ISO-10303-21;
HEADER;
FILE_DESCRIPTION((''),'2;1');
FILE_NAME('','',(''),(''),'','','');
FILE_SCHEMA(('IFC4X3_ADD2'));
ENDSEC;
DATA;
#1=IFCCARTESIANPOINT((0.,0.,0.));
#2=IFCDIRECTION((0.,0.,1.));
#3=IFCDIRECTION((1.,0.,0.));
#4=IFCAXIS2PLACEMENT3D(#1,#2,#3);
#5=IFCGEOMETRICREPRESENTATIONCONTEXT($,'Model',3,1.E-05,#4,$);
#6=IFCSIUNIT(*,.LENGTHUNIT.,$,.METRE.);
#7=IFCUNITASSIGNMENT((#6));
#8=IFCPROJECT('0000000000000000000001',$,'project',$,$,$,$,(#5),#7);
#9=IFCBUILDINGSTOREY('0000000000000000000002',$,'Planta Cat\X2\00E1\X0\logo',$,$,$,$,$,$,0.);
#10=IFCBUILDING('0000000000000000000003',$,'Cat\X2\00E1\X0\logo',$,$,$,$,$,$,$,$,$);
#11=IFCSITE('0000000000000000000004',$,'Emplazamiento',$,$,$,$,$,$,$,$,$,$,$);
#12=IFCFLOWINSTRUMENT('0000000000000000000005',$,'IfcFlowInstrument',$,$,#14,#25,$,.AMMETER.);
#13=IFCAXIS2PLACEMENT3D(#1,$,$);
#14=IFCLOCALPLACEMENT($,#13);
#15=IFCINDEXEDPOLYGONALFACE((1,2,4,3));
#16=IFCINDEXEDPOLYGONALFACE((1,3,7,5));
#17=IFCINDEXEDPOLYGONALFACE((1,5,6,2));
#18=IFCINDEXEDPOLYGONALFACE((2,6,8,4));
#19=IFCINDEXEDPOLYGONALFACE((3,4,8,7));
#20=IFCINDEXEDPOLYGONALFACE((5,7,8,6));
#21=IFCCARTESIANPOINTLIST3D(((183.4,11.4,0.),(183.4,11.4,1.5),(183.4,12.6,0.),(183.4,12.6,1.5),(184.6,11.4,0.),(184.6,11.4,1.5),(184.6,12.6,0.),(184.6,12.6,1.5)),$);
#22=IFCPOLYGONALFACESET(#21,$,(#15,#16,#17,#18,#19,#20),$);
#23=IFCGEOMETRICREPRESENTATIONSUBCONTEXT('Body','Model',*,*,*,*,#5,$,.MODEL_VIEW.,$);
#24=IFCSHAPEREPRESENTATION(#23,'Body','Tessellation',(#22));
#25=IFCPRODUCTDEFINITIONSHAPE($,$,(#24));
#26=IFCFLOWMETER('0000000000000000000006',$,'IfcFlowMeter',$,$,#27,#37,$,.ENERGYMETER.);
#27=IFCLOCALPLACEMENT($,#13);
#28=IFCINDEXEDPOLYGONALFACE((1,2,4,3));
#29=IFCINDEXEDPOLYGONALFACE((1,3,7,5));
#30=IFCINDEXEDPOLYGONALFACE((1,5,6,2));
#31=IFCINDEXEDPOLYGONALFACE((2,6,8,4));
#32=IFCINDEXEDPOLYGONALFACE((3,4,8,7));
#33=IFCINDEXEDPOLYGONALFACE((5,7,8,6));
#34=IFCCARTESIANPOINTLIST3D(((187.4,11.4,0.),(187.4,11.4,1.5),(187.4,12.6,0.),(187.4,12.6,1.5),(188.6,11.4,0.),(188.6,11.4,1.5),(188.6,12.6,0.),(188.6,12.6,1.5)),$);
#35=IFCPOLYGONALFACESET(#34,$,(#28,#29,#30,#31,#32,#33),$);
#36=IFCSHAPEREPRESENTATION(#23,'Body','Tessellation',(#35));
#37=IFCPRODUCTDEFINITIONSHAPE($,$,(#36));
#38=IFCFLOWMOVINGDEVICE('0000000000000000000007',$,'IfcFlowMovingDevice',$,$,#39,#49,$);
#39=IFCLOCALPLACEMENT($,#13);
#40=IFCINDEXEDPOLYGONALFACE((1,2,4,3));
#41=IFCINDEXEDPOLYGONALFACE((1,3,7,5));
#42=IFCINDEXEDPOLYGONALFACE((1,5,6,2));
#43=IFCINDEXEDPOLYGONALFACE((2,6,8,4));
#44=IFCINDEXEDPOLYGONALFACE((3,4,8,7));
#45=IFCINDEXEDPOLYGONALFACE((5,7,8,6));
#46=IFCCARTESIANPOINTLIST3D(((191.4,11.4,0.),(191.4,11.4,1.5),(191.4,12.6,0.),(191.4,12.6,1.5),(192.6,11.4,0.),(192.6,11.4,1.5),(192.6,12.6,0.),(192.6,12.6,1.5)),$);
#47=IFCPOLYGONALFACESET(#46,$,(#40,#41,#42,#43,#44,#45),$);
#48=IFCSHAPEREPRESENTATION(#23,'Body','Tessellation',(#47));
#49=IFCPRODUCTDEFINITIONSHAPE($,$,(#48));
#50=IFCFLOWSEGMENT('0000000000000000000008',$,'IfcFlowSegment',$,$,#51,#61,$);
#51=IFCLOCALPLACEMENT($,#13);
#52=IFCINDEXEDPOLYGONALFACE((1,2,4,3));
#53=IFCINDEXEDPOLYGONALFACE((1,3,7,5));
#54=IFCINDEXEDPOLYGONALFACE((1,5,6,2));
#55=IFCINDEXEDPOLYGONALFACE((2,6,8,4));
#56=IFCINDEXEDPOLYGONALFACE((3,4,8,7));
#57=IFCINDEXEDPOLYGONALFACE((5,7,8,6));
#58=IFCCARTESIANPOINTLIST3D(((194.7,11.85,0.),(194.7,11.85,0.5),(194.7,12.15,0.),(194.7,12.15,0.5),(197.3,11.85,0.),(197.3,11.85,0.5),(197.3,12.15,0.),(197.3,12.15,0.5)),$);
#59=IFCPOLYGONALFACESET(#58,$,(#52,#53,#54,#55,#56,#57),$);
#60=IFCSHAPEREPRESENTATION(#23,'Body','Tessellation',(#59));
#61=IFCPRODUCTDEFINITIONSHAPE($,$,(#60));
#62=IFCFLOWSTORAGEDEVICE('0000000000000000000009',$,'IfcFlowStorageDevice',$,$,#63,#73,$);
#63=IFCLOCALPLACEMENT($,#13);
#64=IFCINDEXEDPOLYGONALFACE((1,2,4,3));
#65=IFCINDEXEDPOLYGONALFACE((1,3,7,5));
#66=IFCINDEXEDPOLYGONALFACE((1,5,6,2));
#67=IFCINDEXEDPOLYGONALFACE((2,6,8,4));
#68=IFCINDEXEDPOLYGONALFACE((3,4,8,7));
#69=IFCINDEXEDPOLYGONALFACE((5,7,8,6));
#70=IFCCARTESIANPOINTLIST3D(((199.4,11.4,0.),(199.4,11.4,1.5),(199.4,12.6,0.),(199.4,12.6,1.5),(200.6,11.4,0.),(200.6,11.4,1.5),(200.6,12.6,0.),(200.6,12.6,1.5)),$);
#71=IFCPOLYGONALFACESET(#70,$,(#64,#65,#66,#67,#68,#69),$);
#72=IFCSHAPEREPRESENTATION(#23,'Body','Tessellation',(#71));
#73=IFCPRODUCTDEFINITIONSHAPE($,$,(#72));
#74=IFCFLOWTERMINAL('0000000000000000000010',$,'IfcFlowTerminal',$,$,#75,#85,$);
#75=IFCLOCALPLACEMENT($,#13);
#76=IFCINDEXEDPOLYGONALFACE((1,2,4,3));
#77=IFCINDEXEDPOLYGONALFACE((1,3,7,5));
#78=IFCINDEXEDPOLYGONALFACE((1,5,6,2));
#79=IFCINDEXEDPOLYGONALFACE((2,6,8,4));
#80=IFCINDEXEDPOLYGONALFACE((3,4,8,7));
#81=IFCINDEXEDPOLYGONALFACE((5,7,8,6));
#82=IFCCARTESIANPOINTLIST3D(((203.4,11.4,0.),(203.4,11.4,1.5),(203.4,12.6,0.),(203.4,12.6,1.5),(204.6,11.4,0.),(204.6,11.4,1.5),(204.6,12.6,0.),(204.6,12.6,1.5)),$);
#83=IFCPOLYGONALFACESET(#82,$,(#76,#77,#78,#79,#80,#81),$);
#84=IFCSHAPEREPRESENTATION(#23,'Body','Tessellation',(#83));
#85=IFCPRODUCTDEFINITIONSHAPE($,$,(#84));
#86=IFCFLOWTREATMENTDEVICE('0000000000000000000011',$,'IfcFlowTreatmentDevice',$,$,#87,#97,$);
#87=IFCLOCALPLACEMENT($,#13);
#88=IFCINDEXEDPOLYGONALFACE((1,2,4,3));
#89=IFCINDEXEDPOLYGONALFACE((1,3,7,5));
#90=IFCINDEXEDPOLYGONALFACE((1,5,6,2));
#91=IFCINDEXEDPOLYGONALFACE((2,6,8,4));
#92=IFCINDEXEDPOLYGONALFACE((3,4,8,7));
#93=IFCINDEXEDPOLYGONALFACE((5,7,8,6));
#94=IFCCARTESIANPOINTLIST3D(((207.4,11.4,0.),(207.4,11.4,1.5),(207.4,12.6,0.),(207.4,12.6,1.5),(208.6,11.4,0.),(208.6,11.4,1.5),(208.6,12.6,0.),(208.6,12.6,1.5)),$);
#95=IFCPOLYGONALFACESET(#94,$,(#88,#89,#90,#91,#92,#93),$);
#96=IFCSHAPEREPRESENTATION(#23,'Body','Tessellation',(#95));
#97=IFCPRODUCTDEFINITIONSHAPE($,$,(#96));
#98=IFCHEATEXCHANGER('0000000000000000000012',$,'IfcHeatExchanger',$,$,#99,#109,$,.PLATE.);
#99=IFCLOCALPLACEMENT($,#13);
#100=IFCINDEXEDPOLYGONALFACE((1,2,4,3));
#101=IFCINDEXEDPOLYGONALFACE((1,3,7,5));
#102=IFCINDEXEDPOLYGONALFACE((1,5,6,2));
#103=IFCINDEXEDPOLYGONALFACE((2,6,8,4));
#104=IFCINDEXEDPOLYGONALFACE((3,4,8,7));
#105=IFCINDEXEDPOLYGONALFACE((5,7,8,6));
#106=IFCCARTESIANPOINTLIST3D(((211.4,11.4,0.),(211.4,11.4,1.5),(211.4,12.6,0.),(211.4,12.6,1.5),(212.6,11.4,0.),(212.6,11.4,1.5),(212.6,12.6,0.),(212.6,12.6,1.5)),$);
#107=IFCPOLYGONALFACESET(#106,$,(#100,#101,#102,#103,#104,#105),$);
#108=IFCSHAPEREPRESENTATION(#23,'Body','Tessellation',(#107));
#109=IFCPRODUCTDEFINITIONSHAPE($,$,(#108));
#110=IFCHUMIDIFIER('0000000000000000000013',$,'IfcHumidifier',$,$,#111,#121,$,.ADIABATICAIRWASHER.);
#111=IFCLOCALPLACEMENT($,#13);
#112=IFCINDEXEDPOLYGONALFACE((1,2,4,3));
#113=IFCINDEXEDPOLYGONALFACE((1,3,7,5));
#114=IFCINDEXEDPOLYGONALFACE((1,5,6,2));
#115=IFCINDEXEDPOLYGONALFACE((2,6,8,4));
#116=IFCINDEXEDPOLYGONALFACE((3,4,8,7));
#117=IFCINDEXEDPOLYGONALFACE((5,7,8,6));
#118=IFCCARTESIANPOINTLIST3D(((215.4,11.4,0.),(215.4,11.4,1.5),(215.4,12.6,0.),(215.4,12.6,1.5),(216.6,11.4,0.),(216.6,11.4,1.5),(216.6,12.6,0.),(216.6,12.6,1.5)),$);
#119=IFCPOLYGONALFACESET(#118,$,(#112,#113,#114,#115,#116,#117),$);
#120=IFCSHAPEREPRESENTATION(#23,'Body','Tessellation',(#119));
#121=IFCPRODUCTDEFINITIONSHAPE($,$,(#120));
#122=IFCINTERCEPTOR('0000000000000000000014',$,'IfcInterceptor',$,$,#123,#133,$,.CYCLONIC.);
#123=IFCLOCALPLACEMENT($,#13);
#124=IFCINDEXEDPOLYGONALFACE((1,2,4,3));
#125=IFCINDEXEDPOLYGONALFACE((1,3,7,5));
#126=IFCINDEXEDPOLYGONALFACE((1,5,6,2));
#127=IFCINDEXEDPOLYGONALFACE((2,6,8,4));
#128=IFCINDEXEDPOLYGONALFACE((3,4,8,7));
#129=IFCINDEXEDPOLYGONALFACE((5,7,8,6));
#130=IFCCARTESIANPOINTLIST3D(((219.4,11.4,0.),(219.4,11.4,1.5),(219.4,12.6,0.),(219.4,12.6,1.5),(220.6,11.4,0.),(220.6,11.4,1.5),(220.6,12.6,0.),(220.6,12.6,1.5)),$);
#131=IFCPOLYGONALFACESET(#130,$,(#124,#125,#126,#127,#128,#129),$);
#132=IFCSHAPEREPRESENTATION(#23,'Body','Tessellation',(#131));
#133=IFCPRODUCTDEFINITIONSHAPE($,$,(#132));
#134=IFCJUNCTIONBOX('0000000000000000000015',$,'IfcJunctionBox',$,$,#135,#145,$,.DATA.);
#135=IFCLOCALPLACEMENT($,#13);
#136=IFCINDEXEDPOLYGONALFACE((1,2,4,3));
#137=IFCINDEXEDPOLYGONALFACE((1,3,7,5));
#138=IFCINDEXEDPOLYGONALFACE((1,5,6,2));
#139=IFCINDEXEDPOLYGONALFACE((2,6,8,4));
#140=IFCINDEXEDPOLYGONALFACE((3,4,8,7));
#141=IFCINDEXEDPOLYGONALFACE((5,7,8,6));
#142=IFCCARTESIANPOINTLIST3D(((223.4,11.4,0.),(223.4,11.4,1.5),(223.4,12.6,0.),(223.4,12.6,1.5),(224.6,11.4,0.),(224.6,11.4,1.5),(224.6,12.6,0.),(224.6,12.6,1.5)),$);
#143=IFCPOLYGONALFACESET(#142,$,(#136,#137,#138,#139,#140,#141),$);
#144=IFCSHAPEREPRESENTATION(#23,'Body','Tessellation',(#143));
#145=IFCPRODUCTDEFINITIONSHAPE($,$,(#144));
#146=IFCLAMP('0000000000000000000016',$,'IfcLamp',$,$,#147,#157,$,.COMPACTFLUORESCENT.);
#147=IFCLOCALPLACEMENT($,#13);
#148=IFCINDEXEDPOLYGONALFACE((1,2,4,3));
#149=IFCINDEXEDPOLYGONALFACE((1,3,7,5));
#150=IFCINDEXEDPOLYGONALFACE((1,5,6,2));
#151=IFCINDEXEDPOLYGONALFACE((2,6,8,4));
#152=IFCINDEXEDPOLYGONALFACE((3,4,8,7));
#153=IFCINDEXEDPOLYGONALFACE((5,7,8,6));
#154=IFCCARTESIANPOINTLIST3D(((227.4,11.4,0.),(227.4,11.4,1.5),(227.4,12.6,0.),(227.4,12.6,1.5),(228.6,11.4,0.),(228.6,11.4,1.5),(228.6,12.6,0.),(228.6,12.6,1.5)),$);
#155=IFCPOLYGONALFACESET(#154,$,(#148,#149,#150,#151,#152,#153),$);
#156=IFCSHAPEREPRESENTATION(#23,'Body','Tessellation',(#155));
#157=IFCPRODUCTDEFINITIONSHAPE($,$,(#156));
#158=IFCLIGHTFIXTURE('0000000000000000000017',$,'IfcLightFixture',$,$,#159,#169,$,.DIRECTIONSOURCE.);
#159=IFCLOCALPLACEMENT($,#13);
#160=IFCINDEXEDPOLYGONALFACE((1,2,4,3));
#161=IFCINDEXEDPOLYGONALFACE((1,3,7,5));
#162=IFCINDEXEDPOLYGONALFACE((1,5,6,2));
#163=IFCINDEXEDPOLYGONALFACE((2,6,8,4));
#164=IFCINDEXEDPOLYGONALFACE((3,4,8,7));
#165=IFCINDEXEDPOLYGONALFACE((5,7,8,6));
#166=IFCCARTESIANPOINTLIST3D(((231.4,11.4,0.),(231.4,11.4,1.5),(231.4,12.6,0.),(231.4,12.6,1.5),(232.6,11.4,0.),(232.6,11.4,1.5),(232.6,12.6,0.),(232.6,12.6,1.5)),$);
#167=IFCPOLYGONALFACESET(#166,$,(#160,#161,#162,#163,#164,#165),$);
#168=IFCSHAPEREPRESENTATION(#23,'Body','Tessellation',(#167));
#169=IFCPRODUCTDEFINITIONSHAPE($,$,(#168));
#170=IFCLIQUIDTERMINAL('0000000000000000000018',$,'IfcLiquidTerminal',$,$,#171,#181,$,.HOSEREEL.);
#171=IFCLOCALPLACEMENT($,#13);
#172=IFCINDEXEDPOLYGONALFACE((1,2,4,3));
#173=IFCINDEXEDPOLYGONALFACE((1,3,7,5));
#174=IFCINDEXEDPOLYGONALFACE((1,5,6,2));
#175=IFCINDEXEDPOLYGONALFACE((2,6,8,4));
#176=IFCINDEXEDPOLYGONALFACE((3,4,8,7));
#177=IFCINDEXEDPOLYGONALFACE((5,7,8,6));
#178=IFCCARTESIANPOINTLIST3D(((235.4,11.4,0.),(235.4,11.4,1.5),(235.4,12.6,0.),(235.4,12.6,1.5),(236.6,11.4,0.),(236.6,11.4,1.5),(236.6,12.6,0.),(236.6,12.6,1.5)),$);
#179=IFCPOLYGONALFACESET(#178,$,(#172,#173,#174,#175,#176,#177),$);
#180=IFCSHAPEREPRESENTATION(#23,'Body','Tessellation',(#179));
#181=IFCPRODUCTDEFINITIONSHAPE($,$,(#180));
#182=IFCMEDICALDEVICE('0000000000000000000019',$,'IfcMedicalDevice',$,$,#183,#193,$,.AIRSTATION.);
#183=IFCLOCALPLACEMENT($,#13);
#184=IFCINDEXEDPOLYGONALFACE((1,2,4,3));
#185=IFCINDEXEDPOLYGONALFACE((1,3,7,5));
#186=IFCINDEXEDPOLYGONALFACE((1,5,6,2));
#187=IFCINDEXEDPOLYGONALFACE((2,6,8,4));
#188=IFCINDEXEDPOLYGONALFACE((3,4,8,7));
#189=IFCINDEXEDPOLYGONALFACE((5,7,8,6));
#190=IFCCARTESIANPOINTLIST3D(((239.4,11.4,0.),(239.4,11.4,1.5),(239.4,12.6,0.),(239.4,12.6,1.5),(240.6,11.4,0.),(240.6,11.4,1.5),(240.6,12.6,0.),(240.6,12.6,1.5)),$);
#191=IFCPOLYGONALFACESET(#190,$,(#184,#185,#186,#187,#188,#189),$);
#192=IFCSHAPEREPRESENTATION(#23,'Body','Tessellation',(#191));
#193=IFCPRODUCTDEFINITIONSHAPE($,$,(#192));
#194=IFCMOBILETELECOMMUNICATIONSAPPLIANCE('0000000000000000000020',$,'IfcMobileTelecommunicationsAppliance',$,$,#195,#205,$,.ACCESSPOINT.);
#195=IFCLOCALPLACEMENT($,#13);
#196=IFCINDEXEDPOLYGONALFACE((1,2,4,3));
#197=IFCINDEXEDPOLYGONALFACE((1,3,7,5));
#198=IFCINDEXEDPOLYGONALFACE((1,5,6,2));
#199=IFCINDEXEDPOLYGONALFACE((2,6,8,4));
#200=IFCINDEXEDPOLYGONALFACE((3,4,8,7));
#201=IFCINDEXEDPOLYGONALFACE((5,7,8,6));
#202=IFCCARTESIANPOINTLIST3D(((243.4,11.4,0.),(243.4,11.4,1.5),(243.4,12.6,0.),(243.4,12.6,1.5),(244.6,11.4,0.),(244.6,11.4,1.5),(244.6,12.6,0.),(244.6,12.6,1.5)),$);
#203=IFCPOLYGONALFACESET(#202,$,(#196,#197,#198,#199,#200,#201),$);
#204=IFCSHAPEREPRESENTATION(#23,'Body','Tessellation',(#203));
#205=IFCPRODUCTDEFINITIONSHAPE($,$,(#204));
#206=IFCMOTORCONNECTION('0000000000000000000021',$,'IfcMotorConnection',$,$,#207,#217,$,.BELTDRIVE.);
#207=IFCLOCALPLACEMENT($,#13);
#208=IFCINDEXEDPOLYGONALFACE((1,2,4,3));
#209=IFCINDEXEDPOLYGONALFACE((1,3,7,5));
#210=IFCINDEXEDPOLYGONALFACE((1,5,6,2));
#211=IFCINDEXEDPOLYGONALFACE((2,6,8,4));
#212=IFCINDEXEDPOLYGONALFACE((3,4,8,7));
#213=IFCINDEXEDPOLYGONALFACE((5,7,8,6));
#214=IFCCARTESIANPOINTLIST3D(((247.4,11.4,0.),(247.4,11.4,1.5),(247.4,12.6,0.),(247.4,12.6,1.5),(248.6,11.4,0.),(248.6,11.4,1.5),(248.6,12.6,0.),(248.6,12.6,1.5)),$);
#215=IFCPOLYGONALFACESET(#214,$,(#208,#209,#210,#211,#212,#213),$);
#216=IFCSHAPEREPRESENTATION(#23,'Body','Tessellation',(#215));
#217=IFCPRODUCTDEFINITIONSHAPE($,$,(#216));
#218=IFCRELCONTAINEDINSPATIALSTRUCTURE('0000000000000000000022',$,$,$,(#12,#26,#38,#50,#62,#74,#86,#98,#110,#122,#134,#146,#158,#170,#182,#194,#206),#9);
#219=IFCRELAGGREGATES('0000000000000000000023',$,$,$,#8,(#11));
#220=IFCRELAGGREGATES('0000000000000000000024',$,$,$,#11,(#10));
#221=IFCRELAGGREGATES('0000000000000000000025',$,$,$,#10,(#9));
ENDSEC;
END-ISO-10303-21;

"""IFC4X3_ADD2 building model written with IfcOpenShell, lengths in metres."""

from ifc_helpers import new_model, si_unit, frame, origin, origin_with_axes, origin_2d, place, context, subcontext, project, spatial, rectangle, extrude, element, save


model = new_model("IFC4X3_ADD2")

# Units and contexts
model_context = context("Model", 3, precision=1e-05, world=origin_with_axes())
body_context = subcontext(model_context, "Body", "Model", "MODEL_VIEW")
ifc_project = project(units=[si_unit("LENGTHUNIT", "METRE")], contexts=[model_context])

# Site, building, storey
site = spatial("IfcSite", under=ifc_project, Name="Emplazamiento")
building = spatial("IfcBuilding", under=site, Name="Catálogo")
storey = spatial("IfcBuildingStorey", under=building, Name="Planta Catálogo", Elevation=0.0)

# Flow instrument
flow_instrument_placement = place(None, frame((184.0, 12.0, 0.0), z_axis=(0.0, 0.0, 1.0), x_axis=(1.0, 0.0, 0.0)))
element("IfcFlowInstrument", 1, at=flow_instrument_placement, inside=storey, Name="IfcFlowInstrument", PredefinedType="AMMETER", context=body_context, shape_type="SweptSolid", body=[
    extrude(rectangle(XDim=1.2, YDim=1.2, at=origin_2d()), origin(), (0.0, 0.0, 1.0), 1.5),
])

# Flow meter
flow_meter_placement = place(None, frame((188.0, 12.0, 0.0), z_axis=(0.0, 0.0, 1.0), x_axis=(1.0, 0.0, 0.0)))
element("IfcFlowMeter", 2, at=flow_meter_placement, inside=storey, Name="IfcFlowMeter", PredefinedType="ENERGYMETER", context=body_context, shape_type="SweptSolid", body=[
    extrude(rectangle(XDim=1.2, YDim=1.2, at=origin_2d()), origin(), (0.0, 0.0, 1.0), 1.5),
])

# Flow moving device
flow_moving_device_placement = place(None, frame((192.0, 12.0, 0.0), z_axis=(0.0, 0.0, 1.0), x_axis=(1.0, 0.0, 0.0)))
element("IfcFlowMovingDevice", 3, at=flow_moving_device_placement, inside=storey, Name="IfcFlowMovingDevice", context=body_context, shape_type="SweptSolid", body=[
    extrude(rectangle(XDim=1.2, YDim=1.2, at=origin_2d()), origin(), (0.0, 0.0, 1.0), 1.5),
])

# Flow segment
flow_segment_placement = place(None, frame((196.0, 12.0, 0.0), z_axis=(0.0, 0.0, 1.0), x_axis=(1.0, 0.0, 0.0)))
element("IfcFlowSegment", 4, at=flow_segment_placement, inside=storey, Name="IfcFlowSegment", context=body_context, shape_type="SweptSolid", body=[
    extrude(rectangle(XDim=2.6, YDim=0.3, at=origin_2d()), origin(), (0.0, 0.0, 1.0), 0.5),
])

# Flow storage device
flow_storage_device_placement = place(None, frame((200.0, 12.0, 0.0), z_axis=(0.0, 0.0, 1.0), x_axis=(1.0, 0.0, 0.0)))
element("IfcFlowStorageDevice", 5, at=flow_storage_device_placement, inside=storey, Name="IfcFlowStorageDevice", context=body_context, shape_type="SweptSolid", body=[
    extrude(rectangle(XDim=1.2, YDim=1.2, at=origin_2d()), origin(), (0.0, 0.0, 1.0), 1.5),
])

# Flow terminal
flow_terminal_placement = place(None, frame((204.0, 12.0, 0.0), z_axis=(0.0, 0.0, 1.0), x_axis=(1.0, 0.0, 0.0)))
element("IfcFlowTerminal", 6, at=flow_terminal_placement, inside=storey, Name="IfcFlowTerminal", context=body_context, shape_type="SweptSolid", body=[
    extrude(rectangle(XDim=1.2, YDim=1.2, at=origin_2d()), origin(), (0.0, 0.0, 1.0), 1.5),
])

# Flow treatment device
flow_treatment_device_placement = place(None, frame((208.0, 12.0, 0.0), z_axis=(0.0, 0.0, 1.0), x_axis=(1.0, 0.0, 0.0)))
element("IfcFlowTreatmentDevice", 7, at=flow_treatment_device_placement, inside=storey, Name="IfcFlowTreatmentDevice", context=body_context, shape_type="SweptSolid", body=[
    extrude(rectangle(XDim=1.2, YDim=1.2, at=origin_2d()), origin(), (0.0, 0.0, 1.0), 1.5),
])

# Heat exchanger
heat_exchanger_placement = place(None, frame((212.0, 12.0, 0.0), z_axis=(0.0, 0.0, 1.0), x_axis=(1.0, 0.0, 0.0)))
element("IfcHeatExchanger", 8, at=heat_exchanger_placement, inside=storey, Name="IfcHeatExchanger", PredefinedType="PLATE", context=body_context, shape_type="SweptSolid", body=[
    extrude(rectangle(XDim=1.2, YDim=1.2, at=origin_2d()), origin(), (0.0, 0.0, 1.0), 1.5),
])

# Humidifier
humidifier_placement = place(None, frame((216.0, 12.0, 0.0), z_axis=(0.0, 0.0, 1.0), x_axis=(1.0, 0.0, 0.0)))
element("IfcHumidifier", 9, at=humidifier_placement, inside=storey, Name="IfcHumidifier", PredefinedType="ADIABATICAIRWASHER", context=body_context, shape_type="SweptSolid", body=[
    extrude(rectangle(XDim=1.2, YDim=1.2, at=origin_2d()), origin(), (0.0, 0.0, 1.0), 1.5),
])

# Interceptor
interceptor_placement = place(None, frame((220.0, 12.0, 0.0), z_axis=(0.0, 0.0, 1.0), x_axis=(1.0, 0.0, 0.0)))
element("IfcInterceptor", 10, at=interceptor_placement, inside=storey, Name="IfcInterceptor", PredefinedType="CYCLONIC", context=body_context, shape_type="SweptSolid", body=[
    extrude(rectangle(XDim=1.2, YDim=1.2, at=origin_2d()), origin(), (0.0, 0.0, 1.0), 1.5),
])

# Junction box
junction_box_placement = place(None, frame((224.0, 12.0, 0.0), z_axis=(0.0, 0.0, 1.0), x_axis=(1.0, 0.0, 0.0)))
element("IfcJunctionBox", 11, at=junction_box_placement, inside=storey, Name="IfcJunctionBox", PredefinedType="DATA", context=body_context, shape_type="SweptSolid", body=[
    extrude(rectangle(XDim=1.2, YDim=1.2, at=origin_2d()), origin(), (0.0, 0.0, 1.0), 1.5),
])

# Lamp
lamp_placement = place(None, frame((228.0, 12.0, 0.0), z_axis=(0.0, 0.0, 1.0), x_axis=(1.0, 0.0, 0.0)))
element("IfcLamp", 12, at=lamp_placement, inside=storey, Name="IfcLamp", PredefinedType="COMPACTFLUORESCENT", context=body_context, shape_type="SweptSolid", body=[
    extrude(rectangle(XDim=1.2, YDim=1.2, at=origin_2d()), origin(), (0.0, 0.0, 1.0), 1.5),
])

# Light fixture
light_fixture_placement = place(None, frame((232.0, 12.0, 0.0), z_axis=(0.0, 0.0, 1.0), x_axis=(1.0, 0.0, 0.0)))
element("IfcLightFixture", 13, at=light_fixture_placement, inside=storey, Name="IfcLightFixture", PredefinedType="DIRECTIONSOURCE", context=body_context, shape_type="SweptSolid", body=[
    extrude(rectangle(XDim=1.2, YDim=1.2, at=origin_2d()), origin(), (0.0, 0.0, 1.0), 1.5),
])

# Liquid terminal
liquid_terminal_placement = place(None, frame((236.0, 12.0, 0.0), z_axis=(0.0, 0.0, 1.0), x_axis=(1.0, 0.0, 0.0)))
element("IfcLiquidTerminal", 14, at=liquid_terminal_placement, inside=storey, Name="IfcLiquidTerminal", PredefinedType="HOSEREEL", context=body_context, shape_type="SweptSolid", body=[
    extrude(rectangle(XDim=1.2, YDim=1.2, at=origin_2d()), origin(), (0.0, 0.0, 1.0), 1.5),
])

# Medical device
medical_device_placement = place(None, frame((240.0, 12.0, 0.0), z_axis=(0.0, 0.0, 1.0), x_axis=(1.0, 0.0, 0.0)))
element("IfcMedicalDevice", 15, at=medical_device_placement, inside=storey, Name="IfcMedicalDevice", PredefinedType="AIRSTATION", context=body_context, shape_type="SweptSolid", body=[
    extrude(rectangle(XDim=1.2, YDim=1.2, at=origin_2d()), origin(), (0.0, 0.0, 1.0), 1.5),
])

# Mobile telecommunications appliance
mobile_telecommunications_appliance_placement = place(None, frame((244.0, 12.0, 0.0), z_axis=(0.0, 0.0, 1.0), x_axis=(1.0, 0.0, 0.0)))
element("IfcMobileTelecommunicationsAppliance", 16, at=mobile_telecommunications_appliance_placement, inside=storey, Name="IfcMobileTelecommunicationsAppliance", PredefinedType="ACCESSPOINT", context=body_context, shape_type="SweptSolid", body=[
    extrude(rectangle(XDim=1.2, YDim=1.2, at=origin_2d()), origin(), (0.0, 0.0, 1.0), 1.5),
])

# Motor connection
motor_connection_placement = place(None, frame((248.0, 12.0, 0.0), z_axis=(0.0, 0.0, 1.0), x_axis=(1.0, 0.0, 0.0)))
element("IfcMotorConnection", 17, at=motor_connection_placement, inside=storey, Name="IfcMotorConnection", PredefinedType="BELTDRIVE", context=body_context, shape_type="SweptSolid", body=[
    extrude(rectangle(XDim=1.2, YDim=1.2, at=origin_2d()), origin(), (0.0, 0.0, 1.0), 1.5),
])

save(model, "model.ifc")
